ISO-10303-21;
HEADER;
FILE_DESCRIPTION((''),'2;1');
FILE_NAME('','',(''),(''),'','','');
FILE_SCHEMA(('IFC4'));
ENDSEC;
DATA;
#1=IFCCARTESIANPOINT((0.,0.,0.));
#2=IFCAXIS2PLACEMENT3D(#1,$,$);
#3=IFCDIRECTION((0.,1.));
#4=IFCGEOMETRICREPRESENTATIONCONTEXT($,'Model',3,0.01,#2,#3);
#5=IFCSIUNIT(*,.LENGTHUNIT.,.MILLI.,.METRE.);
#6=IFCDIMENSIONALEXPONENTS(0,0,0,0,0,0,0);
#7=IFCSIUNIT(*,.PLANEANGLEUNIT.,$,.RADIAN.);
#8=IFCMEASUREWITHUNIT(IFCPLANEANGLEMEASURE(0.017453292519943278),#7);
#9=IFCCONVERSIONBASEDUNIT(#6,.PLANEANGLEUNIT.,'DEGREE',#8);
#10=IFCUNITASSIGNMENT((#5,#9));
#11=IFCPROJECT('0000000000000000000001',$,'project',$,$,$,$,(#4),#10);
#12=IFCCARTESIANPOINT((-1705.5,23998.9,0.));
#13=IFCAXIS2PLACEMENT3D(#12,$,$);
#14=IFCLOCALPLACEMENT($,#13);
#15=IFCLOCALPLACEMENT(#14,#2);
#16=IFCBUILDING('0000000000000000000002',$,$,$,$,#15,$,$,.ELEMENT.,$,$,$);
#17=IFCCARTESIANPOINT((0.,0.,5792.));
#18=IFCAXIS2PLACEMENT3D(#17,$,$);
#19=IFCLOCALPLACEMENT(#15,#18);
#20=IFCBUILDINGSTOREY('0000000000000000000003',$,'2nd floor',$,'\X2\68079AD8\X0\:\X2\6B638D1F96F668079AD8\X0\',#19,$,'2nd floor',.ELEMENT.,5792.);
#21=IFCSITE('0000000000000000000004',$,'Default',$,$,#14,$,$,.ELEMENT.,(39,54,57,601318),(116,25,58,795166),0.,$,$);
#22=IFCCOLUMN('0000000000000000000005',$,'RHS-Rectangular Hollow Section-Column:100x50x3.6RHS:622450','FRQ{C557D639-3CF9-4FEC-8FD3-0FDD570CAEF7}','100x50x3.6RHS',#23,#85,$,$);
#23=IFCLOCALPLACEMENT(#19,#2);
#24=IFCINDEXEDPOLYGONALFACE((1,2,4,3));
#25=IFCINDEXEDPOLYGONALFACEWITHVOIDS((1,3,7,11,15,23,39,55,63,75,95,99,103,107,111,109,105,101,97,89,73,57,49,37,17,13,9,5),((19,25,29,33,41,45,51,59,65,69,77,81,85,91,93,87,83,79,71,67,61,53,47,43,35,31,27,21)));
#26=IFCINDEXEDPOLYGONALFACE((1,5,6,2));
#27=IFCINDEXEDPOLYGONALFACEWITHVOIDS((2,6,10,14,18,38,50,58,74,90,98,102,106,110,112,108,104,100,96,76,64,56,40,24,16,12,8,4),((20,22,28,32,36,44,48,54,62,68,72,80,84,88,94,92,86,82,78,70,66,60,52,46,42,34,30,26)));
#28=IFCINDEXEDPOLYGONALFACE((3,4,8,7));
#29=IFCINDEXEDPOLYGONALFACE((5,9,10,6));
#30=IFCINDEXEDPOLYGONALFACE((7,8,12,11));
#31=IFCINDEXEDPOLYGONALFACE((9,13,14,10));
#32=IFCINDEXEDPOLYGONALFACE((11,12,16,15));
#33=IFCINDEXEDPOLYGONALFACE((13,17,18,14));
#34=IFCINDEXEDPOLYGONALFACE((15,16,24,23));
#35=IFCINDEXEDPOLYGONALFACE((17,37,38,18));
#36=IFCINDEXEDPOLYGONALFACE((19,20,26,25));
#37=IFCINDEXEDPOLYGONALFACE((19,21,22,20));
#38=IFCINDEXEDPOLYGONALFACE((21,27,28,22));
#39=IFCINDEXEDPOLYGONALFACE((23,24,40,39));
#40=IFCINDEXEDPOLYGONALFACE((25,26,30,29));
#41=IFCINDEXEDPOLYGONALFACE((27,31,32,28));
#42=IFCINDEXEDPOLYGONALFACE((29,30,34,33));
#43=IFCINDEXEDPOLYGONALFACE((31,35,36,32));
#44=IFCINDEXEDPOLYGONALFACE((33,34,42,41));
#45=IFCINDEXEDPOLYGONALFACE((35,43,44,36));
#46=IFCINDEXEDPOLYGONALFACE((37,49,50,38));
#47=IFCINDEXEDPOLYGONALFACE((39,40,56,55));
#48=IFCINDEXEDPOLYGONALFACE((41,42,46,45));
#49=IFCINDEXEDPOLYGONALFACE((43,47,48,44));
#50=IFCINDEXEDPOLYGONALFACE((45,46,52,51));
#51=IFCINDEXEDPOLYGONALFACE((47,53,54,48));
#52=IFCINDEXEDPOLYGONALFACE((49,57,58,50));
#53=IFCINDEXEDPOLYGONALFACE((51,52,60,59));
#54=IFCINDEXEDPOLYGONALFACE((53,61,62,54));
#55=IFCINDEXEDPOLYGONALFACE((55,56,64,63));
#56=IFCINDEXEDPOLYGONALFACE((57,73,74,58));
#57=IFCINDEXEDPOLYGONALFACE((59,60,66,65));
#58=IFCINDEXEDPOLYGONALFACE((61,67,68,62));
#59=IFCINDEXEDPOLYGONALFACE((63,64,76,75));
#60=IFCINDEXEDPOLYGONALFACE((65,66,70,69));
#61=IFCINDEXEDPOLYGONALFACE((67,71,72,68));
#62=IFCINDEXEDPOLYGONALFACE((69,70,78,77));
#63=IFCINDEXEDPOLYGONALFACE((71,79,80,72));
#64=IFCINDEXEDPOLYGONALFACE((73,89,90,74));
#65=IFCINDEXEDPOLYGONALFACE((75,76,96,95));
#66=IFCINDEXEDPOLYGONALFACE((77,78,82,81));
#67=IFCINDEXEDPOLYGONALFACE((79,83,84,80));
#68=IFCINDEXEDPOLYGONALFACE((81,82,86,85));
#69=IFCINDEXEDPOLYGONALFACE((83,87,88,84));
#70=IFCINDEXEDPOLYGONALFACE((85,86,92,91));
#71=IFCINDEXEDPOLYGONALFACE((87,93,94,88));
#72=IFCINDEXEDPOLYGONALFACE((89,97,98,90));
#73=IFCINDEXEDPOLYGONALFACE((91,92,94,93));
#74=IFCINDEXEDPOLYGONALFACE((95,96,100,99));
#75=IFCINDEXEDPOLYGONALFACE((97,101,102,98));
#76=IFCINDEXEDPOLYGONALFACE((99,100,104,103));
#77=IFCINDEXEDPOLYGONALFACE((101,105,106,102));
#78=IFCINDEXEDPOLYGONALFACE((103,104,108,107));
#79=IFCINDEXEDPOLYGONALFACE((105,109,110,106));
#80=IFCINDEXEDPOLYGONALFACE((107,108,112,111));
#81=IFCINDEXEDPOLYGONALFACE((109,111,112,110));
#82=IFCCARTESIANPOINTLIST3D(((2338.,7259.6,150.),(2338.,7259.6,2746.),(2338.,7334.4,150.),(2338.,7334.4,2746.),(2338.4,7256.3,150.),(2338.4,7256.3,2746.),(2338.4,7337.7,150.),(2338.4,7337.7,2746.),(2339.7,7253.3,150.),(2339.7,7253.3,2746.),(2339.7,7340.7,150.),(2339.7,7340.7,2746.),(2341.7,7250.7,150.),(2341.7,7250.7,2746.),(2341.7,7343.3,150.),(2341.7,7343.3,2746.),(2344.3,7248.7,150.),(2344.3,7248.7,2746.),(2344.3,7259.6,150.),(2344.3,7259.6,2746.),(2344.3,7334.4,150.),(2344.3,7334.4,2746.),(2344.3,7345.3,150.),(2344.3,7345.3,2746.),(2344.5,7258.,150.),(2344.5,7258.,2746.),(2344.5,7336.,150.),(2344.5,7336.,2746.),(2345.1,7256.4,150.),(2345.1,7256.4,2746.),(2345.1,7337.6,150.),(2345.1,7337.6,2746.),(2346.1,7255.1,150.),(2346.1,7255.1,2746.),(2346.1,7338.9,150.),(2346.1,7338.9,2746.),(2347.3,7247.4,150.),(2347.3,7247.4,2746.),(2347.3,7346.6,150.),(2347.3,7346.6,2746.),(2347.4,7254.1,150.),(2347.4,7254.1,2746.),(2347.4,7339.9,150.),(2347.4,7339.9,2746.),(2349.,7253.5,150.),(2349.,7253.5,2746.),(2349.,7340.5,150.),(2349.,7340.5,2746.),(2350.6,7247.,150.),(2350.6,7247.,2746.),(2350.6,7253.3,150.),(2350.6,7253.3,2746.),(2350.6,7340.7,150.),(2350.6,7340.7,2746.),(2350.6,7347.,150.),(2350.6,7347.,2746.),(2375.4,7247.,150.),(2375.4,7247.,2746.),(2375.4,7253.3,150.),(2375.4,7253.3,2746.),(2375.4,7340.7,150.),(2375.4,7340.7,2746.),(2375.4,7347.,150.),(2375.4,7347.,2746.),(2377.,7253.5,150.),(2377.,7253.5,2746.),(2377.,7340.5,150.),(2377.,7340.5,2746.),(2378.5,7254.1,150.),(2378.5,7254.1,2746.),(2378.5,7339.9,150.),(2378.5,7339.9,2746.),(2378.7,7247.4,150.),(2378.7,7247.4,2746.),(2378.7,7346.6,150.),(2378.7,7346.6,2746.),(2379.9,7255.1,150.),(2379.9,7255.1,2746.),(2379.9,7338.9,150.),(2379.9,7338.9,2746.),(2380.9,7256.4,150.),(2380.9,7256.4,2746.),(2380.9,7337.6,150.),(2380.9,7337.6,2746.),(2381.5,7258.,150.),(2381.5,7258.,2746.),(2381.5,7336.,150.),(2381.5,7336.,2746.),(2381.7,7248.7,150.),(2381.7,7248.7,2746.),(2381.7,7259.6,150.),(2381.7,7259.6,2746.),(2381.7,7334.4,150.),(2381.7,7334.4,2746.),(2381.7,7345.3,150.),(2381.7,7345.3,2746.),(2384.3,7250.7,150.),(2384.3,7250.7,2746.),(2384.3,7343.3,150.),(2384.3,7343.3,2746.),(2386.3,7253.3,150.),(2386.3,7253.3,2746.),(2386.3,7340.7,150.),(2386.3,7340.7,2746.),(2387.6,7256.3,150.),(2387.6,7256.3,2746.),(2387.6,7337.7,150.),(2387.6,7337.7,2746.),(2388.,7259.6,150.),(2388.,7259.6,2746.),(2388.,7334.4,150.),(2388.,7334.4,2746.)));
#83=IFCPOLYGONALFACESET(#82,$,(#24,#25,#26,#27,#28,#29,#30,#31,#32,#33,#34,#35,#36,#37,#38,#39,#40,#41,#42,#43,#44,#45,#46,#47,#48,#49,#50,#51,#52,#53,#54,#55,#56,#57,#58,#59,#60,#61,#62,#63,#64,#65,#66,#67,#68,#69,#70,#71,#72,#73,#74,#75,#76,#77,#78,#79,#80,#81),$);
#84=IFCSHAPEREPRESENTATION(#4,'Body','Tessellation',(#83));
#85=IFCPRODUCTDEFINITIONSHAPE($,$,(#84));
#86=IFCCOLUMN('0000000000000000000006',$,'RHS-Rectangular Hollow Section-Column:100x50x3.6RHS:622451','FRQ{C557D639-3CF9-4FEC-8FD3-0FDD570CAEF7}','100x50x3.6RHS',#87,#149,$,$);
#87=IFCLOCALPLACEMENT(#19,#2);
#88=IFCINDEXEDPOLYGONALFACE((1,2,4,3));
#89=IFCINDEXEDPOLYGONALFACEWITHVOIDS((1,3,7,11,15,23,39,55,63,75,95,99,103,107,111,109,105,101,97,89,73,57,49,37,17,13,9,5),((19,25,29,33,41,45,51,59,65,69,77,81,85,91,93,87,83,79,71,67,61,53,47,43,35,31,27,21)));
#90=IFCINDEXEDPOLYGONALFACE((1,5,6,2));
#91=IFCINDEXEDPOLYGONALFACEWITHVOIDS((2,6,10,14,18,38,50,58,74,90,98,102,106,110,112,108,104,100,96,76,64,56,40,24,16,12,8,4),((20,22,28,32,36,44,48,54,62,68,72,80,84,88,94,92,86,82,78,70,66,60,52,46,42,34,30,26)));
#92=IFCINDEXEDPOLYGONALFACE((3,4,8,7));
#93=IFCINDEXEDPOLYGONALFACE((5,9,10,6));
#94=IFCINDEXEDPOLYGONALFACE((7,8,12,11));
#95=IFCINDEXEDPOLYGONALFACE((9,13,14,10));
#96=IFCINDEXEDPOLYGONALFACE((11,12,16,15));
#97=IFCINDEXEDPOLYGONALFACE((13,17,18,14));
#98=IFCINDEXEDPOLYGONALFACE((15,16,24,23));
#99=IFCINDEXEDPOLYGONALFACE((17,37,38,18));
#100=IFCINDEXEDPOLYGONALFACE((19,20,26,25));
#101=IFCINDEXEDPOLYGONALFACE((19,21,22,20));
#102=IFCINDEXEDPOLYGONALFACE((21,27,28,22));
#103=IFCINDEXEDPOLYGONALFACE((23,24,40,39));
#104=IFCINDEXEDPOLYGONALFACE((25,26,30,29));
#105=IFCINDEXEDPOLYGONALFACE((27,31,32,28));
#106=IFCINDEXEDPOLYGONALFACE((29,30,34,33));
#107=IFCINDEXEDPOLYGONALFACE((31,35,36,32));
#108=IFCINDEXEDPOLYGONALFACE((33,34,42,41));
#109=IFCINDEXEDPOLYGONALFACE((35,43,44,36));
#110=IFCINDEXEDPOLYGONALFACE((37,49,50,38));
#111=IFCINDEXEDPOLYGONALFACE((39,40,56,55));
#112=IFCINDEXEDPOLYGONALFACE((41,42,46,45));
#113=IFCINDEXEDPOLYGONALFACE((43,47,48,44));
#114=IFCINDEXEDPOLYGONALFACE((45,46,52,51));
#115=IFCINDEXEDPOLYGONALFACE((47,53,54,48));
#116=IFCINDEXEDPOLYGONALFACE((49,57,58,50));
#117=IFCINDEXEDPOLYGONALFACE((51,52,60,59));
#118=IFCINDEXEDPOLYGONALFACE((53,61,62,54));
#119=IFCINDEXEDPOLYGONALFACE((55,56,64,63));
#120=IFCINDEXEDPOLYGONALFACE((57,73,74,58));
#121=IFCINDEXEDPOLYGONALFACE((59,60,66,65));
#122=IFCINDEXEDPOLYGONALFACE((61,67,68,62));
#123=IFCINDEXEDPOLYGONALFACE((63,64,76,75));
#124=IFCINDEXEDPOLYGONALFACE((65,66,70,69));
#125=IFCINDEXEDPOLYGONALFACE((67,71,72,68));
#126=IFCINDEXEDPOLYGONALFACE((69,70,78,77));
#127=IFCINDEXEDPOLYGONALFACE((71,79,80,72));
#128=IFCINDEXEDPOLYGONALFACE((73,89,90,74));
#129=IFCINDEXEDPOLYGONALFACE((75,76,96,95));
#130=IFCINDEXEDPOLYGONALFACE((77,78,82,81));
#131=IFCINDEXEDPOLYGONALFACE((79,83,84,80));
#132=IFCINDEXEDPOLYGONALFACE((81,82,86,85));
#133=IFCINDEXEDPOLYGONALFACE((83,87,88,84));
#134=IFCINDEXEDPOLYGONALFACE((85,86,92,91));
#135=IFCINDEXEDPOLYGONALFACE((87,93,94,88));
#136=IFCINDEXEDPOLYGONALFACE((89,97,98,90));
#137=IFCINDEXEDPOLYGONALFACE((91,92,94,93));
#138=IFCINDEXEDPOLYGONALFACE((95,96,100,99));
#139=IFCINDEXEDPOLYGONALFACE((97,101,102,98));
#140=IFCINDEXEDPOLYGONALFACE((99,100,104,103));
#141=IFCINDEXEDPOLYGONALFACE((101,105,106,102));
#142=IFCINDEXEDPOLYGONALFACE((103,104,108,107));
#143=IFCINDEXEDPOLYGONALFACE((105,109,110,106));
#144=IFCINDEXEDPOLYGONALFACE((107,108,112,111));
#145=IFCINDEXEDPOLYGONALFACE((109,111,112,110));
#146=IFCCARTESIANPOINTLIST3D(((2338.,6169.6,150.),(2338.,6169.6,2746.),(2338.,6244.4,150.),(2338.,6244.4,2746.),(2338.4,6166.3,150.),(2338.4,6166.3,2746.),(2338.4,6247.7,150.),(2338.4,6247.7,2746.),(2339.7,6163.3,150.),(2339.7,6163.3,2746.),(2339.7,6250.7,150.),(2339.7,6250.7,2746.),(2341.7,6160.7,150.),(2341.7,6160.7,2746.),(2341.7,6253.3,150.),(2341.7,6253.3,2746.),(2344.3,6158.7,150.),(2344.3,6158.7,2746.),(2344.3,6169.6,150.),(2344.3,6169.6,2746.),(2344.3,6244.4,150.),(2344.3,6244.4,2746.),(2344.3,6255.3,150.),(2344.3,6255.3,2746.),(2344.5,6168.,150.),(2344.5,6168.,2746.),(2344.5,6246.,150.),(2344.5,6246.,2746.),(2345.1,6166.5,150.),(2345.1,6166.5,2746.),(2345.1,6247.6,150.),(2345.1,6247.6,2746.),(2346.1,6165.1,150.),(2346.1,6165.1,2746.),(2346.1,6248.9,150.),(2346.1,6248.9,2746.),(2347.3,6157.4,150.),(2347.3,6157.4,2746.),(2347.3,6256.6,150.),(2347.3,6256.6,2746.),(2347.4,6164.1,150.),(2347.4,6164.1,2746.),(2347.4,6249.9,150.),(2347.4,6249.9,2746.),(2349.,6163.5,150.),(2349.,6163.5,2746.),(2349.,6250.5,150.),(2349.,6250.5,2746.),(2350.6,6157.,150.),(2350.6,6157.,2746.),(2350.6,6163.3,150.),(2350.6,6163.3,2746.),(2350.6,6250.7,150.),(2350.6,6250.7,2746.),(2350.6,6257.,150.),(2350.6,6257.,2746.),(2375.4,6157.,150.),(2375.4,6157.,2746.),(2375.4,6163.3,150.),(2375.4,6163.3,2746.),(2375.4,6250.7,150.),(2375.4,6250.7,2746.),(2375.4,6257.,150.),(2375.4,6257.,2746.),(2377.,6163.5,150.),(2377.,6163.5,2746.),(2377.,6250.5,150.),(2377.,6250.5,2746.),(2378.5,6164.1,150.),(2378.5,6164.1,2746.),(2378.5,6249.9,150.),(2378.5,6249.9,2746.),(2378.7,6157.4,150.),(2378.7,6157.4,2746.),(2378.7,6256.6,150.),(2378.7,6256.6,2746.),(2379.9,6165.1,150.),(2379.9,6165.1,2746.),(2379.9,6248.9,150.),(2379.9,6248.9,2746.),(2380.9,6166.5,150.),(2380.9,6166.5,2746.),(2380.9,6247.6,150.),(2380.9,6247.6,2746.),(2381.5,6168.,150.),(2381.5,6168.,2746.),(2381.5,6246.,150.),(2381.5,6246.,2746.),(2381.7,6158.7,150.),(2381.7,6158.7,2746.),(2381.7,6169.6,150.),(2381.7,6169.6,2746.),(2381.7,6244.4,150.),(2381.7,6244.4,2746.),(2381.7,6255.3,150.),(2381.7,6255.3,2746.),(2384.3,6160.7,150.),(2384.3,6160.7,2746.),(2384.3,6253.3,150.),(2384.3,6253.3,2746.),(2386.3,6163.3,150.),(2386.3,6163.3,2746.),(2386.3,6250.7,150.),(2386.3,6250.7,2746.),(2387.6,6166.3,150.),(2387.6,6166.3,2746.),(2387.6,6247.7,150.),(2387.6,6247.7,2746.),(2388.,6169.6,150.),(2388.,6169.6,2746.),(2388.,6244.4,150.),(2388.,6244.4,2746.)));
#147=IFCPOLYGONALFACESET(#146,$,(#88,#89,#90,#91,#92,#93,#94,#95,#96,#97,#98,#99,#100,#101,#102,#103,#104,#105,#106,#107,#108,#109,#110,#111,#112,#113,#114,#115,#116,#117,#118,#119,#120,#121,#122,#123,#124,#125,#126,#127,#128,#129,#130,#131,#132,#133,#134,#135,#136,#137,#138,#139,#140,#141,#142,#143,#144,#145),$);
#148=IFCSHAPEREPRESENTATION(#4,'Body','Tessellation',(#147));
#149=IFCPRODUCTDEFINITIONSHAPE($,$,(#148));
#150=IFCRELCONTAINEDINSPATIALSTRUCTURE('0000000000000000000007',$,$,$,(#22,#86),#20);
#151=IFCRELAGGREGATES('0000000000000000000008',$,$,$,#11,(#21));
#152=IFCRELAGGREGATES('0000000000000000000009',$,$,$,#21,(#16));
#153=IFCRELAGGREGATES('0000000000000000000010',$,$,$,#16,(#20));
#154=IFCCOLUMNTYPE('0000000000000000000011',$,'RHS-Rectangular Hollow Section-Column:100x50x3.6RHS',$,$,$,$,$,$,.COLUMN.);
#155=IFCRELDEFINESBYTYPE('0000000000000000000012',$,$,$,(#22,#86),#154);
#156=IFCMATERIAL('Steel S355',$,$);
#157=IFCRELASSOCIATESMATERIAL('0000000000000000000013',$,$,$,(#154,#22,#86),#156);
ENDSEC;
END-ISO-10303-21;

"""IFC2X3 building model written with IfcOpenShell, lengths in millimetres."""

from ifc_helpers import new_model, entity, si_unit, converted_unit, direction, frame, origin, origin_2d, place, context, project, spatial, hollow_rectangle, extrude, clip, halfspace, material, type_object, element, save


model = new_model("IFC2X3")

# Units and contexts
model_context = context("Model", 3, precision=0.01, world=origin(), true_north=direction((0.0, 1.0)))
ifc_project = project(units=[si_unit("LENGTHUNIT", "METRE", prefix="MILLI"), converted_unit("PLANEANGLEUNIT", "DEGREE", entity("IfcPlaneAngleMeasure", 0.017453292519943278), si_unit("PLANEANGLEUNIT", "RADIAN"), dimensions=[0, 0, 0, 0, 0, 0, 0])], contexts=[model_context])

# Site, building, storey
site_placement = place(None, frame((-1705.5, 23998.9, 0.0)))
site = spatial("IfcSite", under=ifc_project, at=site_placement, Name="Default", CompositionType="ELEMENT", RefLatitude=(39, 54, 57, 601318), RefLongitude=(116, 25, 58, 795166), RefElevation=0.0)
building_placement = place(site_placement, origin())
building = spatial("IfcBuilding", under=site, at=building_placement, CompositionType="ELEMENT")
storey_placement = place(building_placement, frame((0.0, 0.0, 5792.0)))
storey = spatial("IfcBuildingStorey", under=building, at=storey_placement, Name="2nd floor", ObjectType="标高:正负零标高", LongName="2nd floor", CompositionType="ELEMENT", Elevation=5792.0)

# Columns
ifc_material_1 = material(Name="Steel S355")
column_type_1 = type_object("IfcColumnType", Name="RHS-Rectangular Hollow Section-Column:100x50x3.6RHS", PredefinedType="COLUMN", material=ifc_material_1)
column_1_placement = place(storey_placement, frame((2363.0, 7297.0, 2746.0), z_axis=(0.0, 0.0, 1.0), x_axis=(-1.0, 0.0, 0.0)))
element("IfcColumn", 1, at=column_1_placement, inside=storey, type_object=column_type_1, material=ifc_material_1, Name="RHS-Rectangular Hollow Section-Column:100x50x3.6RHS:622450", Description="FRQ{C557D639-3CF9-4FEC-8FD3-0FDD570CAEF7}", ObjectType="100x50x3.6RHS", context=model_context, shape_type="Clipping", body=[
    clip(extrude(hollow_rectangle(XDim=50.0, YDim=100.0, WallThickness=6.3, InnerFilletRadius=6.3, OuterFilletRadius=12.6, at=origin_2d()), origin(), (0.0, 0.0, -1.0), 2651.9), halfspace(frame((2363.0, 7297.0, -2596.0), z_axis=(0.0, 0.0, 1.0), x_axis=(-1.0, 0.0, 0.0)), True)),
])
column_2_placement = place(storey_placement, frame((2363.0, 6207.0, 2746.0), z_axis=(0.0, 0.0, 1.0), x_axis=(-1.0, 0.0, 0.0)))
element("IfcColumn", 2, at=column_2_placement, inside=storey, type_object=column_type_1, material=ifc_material_1, Name="RHS-Rectangular Hollow Section-Column:100x50x3.6RHS:622451", Description="FRQ{C557D639-3CF9-4FEC-8FD3-0FDD570CAEF7}", ObjectType="100x50x3.6RHS", context=model_context, shape_type="Clipping", body=[
    clip(extrude(hollow_rectangle(XDim=50.0, YDim=100.0, WallThickness=6.3, InnerFilletRadius=6.3, OuterFilletRadius=12.6, at=origin_2d()), origin(), (0.0, 0.0, -1.0), 2651.9), halfspace(frame((2363.0, 6207.0, -2596.0), z_axis=(0.0, 0.0, 1.0), x_axis=(-1.0, 0.0, 0.0)), True)),
])

save(model, "model.ifc")
